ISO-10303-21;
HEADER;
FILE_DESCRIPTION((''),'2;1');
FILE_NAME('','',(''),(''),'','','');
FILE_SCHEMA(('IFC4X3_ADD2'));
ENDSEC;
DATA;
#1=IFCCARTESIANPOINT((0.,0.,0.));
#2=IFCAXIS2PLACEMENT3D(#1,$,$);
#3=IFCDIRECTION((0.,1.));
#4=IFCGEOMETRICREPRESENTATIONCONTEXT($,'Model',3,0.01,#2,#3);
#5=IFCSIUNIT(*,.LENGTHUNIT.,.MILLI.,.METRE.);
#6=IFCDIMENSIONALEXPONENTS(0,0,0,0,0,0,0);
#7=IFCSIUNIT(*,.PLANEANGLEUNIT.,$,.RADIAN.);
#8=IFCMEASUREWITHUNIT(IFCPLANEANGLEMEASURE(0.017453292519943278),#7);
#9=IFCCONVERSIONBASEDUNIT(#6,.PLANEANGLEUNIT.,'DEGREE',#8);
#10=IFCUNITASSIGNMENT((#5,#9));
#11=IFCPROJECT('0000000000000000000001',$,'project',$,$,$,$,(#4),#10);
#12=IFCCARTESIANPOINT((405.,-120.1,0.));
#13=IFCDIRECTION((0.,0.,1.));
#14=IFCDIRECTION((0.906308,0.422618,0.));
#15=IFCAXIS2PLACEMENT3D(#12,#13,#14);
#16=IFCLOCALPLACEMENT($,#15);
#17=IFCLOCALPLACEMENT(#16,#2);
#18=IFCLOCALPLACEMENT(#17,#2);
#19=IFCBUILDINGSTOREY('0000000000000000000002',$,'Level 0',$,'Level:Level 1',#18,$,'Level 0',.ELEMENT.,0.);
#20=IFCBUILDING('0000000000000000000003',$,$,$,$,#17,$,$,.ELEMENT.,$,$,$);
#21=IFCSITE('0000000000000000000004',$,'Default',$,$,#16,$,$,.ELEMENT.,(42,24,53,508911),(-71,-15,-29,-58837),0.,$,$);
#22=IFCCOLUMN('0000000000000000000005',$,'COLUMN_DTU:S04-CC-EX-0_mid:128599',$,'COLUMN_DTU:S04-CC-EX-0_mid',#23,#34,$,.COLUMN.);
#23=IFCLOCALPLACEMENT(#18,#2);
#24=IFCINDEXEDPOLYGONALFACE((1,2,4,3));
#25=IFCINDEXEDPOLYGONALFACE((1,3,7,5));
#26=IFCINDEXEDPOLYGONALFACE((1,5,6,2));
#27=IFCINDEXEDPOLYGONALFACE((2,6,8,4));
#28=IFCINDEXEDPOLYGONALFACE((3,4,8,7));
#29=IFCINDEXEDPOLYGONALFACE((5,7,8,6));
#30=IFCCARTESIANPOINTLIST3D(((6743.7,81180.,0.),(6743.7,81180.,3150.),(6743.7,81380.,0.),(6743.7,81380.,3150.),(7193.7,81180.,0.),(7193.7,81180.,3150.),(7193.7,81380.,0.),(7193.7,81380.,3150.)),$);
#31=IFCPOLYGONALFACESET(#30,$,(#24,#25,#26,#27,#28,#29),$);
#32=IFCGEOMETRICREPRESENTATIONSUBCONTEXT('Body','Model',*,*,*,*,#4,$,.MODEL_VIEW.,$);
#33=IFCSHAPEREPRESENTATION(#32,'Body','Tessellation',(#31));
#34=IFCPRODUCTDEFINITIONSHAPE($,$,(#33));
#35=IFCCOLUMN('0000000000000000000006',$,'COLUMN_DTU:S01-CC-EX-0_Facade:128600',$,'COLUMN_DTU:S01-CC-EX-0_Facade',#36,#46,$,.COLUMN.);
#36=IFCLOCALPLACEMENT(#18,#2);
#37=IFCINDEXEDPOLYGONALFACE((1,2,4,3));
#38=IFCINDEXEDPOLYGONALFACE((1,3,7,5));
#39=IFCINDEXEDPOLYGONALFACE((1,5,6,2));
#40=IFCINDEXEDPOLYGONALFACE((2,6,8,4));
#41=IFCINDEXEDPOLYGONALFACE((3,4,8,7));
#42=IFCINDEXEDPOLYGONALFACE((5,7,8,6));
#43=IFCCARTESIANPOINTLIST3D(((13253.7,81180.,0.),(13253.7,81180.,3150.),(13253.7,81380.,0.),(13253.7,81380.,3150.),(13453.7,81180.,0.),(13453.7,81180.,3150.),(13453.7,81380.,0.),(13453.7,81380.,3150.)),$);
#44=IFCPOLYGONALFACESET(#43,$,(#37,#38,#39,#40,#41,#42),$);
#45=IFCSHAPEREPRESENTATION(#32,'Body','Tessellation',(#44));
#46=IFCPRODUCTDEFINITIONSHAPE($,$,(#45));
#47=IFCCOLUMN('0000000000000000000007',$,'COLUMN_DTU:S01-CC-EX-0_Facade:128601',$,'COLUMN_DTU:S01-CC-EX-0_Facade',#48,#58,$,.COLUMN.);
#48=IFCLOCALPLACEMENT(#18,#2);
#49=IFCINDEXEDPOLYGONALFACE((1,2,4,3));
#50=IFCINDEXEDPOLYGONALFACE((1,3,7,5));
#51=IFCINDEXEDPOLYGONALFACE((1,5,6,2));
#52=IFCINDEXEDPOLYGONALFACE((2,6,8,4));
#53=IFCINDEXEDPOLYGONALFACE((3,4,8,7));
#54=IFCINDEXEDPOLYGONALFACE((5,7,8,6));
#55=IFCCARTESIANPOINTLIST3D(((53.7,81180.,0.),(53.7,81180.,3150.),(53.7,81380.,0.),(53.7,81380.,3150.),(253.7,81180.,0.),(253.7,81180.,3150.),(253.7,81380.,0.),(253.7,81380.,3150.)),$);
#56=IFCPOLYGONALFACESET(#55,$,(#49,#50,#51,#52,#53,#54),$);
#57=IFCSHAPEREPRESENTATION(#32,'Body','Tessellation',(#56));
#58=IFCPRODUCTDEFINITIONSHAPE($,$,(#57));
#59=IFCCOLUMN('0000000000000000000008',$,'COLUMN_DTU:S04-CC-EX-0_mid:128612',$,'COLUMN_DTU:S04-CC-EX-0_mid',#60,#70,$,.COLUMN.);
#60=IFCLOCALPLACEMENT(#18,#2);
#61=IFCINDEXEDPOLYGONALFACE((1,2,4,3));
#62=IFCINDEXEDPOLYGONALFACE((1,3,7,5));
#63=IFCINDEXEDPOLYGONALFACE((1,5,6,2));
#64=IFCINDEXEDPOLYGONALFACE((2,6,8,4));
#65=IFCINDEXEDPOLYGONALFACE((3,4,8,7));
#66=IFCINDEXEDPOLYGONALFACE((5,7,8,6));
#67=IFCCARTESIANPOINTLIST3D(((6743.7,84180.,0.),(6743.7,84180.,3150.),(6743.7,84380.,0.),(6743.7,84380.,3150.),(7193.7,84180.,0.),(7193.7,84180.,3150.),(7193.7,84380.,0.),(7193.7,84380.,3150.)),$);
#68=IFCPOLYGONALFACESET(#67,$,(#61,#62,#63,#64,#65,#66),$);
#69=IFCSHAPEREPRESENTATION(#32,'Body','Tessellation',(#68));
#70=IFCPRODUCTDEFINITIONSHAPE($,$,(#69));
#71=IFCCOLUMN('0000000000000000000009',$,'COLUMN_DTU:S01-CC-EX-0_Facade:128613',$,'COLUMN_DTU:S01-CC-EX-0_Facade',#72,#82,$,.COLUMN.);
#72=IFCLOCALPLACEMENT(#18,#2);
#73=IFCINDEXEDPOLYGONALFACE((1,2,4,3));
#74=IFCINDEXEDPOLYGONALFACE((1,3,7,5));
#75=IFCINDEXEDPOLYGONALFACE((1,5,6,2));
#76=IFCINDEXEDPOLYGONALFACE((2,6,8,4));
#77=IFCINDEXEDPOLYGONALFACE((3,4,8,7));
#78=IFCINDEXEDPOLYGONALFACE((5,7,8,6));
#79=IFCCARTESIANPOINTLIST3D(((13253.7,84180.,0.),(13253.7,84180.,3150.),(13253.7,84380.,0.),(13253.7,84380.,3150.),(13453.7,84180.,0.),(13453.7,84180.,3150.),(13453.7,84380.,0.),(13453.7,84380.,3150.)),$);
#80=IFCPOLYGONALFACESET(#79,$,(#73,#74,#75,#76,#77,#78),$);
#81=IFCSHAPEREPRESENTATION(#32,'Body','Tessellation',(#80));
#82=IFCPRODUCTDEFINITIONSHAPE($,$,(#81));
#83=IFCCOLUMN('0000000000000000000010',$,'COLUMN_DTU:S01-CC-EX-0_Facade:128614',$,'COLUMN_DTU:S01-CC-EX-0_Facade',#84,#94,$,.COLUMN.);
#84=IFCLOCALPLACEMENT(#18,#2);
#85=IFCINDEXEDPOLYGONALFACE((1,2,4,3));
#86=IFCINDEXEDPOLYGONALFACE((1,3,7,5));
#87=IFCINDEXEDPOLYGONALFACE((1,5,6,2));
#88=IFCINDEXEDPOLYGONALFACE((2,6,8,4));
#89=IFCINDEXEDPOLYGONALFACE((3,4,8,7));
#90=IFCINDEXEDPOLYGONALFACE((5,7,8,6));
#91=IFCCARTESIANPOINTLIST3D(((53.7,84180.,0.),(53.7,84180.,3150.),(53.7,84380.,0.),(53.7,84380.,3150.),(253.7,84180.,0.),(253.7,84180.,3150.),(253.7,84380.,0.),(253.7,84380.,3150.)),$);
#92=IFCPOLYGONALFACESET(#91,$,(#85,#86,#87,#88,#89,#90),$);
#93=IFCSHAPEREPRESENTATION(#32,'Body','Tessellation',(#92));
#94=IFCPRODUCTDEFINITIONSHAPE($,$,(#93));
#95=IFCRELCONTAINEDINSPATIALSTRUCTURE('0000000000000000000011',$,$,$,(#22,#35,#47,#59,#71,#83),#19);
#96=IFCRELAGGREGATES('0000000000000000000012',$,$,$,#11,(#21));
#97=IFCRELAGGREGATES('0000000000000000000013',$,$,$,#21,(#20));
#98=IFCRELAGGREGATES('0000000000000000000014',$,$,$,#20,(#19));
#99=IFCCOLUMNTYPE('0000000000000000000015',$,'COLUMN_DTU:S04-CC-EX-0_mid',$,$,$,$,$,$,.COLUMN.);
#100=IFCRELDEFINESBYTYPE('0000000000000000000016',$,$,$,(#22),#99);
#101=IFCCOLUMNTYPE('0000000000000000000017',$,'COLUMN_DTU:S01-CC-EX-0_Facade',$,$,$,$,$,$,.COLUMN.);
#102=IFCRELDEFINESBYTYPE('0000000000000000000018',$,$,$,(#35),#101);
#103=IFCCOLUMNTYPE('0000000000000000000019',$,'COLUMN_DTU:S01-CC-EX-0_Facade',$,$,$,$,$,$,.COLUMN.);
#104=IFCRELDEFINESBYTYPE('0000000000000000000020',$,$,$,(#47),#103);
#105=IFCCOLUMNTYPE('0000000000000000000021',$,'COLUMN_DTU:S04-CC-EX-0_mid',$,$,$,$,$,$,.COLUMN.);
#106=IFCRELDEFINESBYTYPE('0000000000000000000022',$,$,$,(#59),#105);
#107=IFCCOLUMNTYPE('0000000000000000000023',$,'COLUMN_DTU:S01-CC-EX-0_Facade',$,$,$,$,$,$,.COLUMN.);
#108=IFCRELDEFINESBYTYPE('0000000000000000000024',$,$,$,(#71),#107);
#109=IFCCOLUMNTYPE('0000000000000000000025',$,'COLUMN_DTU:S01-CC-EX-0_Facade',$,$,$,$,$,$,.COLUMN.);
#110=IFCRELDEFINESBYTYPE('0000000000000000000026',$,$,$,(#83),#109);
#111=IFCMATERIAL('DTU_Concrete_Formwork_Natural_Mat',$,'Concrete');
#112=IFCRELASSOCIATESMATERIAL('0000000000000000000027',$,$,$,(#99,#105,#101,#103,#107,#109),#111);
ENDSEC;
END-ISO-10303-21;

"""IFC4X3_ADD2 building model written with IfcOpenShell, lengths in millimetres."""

from ifc_helpers import new_model, entity, si_unit, converted_unit, direction, frame, frame_2d, origin, place, context, subcontext, project, spatial, rectangle, extrude, source, transform, mapped, material, material_profile, profile_set, type_object, type_shapes, element, save


model = new_model("IFC4X3_ADD2")

# Units and contexts
model_context = context("Model", 3, precision=0.01, world=origin(), true_north=direction((0.0, 1.0)))
body_context = subcontext(model_context, "Body", "Model", "MODEL_VIEW")
ifc_project = project(units=[si_unit("LENGTHUNIT", "METRE", prefix="MILLI"), converted_unit("PLANEANGLEUNIT", "DEGREE", entity("IfcPlaneAngleMeasure", 0.017453292519943278), si_unit("PLANEANGLEUNIT", "RADIAN"), dimensions=[0, 0, 0, 0, 0, 0, 0])], contexts=[model_context])

# Site, building, storey
site_placement = place(None, frame((405.0, -120.1, 0.0), z_axis=(0.0, 0.0, 1.0), x_axis=(0.906308, 0.422618, 0.0)))
site = spatial("IfcSite", under=ifc_project, at=site_placement, Name="Default", CompositionType="ELEMENT", RefLatitude=(42, 24, 53, 508911), RefLongitude=(-71, -15, -29, -58837), RefElevation=0.0)
building_placement = place(site_placement, origin())
building = spatial("IfcBuilding", under=site, at=building_placement, CompositionType="ELEMENT")
storey_placement = place(building_placement, origin())
storey = spatial("IfcBuildingStorey", under=building, at=storey_placement, Name="Level 0", ObjectType="Level:Level 1", LongName="Level 0", CompositionType="ELEMENT", Elevation=0.0)

# Columns
ifc_material = material(Name="DTU_Concrete_Formwork_Natural_Mat", Category="Concrete")
ifc_material_profile_1 = material_profile(ifc_material, rectangle(XDim=200.0, YDim=200.0, at=frame_2d((0.0, 0.0), x_axis=(1.0, 0.0))), Name="S01-CC-EX-0_Facade")
ifc_profile_set_1 = profile_set([ifc_material_profile_1], Name="S01-CC-EX-0_Facade")
ifc_material_profile_2 = material_profile(ifc_material, rectangle(XDim=200.0, YDim=450.0, at=frame_2d((0.0, 0.0), x_axis=(1.0, 0.0))), Name="S04-CC-EX-0_mid")
ifc_profile_set_2 = profile_set([ifc_material_profile_2], Name="S04-CC-EX-0_mid")
column_type_1 = type_object("IfcColumnType", Name="COLUMN_DTU:S04-CC-EX-0_mid", PredefinedType="COLUMN", material=ifc_profile_set_2)
shared_shape_1 = source(origin(), body_context, "Body", "SweptSolid", [
    extrude(rectangle(XDim=200.0, YDim=450.0, at=frame_2d((0.0, 0.0), x_axis=(1.0, 0.0))), frame((6968.7, 81280.0, 0.0), z_axis=(0.0, 0.0, 1.0), x_axis=(0.0, 1.0, 0.0)), (0.0, 0.0, 1.0), 3150.0),
])
type_shapes(column_type_1, [shared_shape_1])
column_1_placement = place(storey_placement, origin())
element("IfcColumn", 1, at=column_1_placement, inside=storey, type_object=column_type_1, Name="COLUMN_DTU:S04-CC-EX-0_mid:128599", ObjectType="COLUMN_DTU:S04-CC-EX-0_mid", PredefinedType="COLUMN", context=body_context, shape_type="MappedRepresentation", body=[
    mapped(shared_shape_1, transform((0.0, 0.0, 0.0), scale=1.0)),
])
column_type_2 = type_object("IfcColumnType", Name="COLUMN_DTU:S01-CC-EX-0_Facade", PredefinedType="COLUMN", material=ifc_profile_set_1)
shared_shape_2 = source(origin(), body_context, "Body", "SweptSolid", [
    extrude(rectangle(XDim=200.0, YDim=200.0, at=frame_2d((0.0, 0.0), x_axis=(1.0, 0.0))), frame((13353.7, 81280.0, 0.0), z_axis=(0.0, 0.0, 1.0), x_axis=(0.0, 1.0, 0.0)), (0.0, 0.0, 1.0), 3150.0),
])
type_shapes(column_type_2, [shared_shape_2])
column_2_placement = place(storey_placement, origin())
element("IfcColumn", 2, at=column_2_placement, inside=storey, type_object=column_type_2, Name="COLUMN_DTU:S01-CC-EX-0_Facade:128600", ObjectType="COLUMN_DTU:S01-CC-EX-0_Facade", PredefinedType="COLUMN", context=body_context, shape_type="MappedRepresentation", body=[
    mapped(shared_shape_2, transform((0.0, 0.0, 0.0), scale=1.0)),
])
column_type_3 = type_object("IfcColumnType", Name="COLUMN_DTU:S01-CC-EX-0_Facade", PredefinedType="COLUMN", material=ifc_profile_set_1)
shared_shape_3 = source(origin(), body_context, "Body", "SweptSolid", [
    extrude(rectangle(XDim=200.0, YDim=200.0, at=frame_2d((0.0, 0.0), x_axis=(1.0, 0.0))), frame((153.7, 81280.0, 0.0), z_axis=(0.0, 0.0, 1.0), x_axis=(0.0, 1.0, 0.0)), (0.0, 0.0, 1.0), 3150.0),
])
type_shapes(column_type_3, [shared_shape_3])
column_3_placement = place(storey_placement, origin())
element("IfcColumn", 3, at=column_3_placement, inside=storey, type_object=column_type_3, Name="COLUMN_DTU:S01-CC-EX-0_Facade:128601", ObjectType="COLUMN_DTU:S01-CC-EX-0_Facade", PredefinedType="COLUMN", context=body_context, shape_type="MappedRepresentation", body=[
    mapped(shared_shape_3, transform((0.0, 0.0, 0.0), scale=1.0)),
])
column_type_4 = type_object("IfcColumnType", Name="COLUMN_DTU:S04-CC-EX-0_mid", PredefinedType="COLUMN", material=ifc_profile_set_2)
shared_shape_4 = source(origin(), body_context, "Body", "SweptSolid", [
    extrude(rectangle(XDim=200.0, YDim=450.0, at=frame_2d((0.0, 0.0), x_axis=(1.0, 0.0))), frame((6968.7, 84280.0, 0.0), z_axis=(0.0, 0.0, 1.0), x_axis=(0.0, 1.0, 0.0)), (0.0, 0.0, 1.0), 3150.0),
])
type_shapes(column_type_4, [shared_shape_4])
column_4_placement = place(storey_placement, origin())
element("IfcColumn", 4, at=column_4_placement, inside=storey, type_object=column_type_4, Name="COLUMN_DTU:S04-CC-EX-0_mid:128612", ObjectType="COLUMN_DTU:S04-CC-EX-0_mid", PredefinedType="COLUMN", context=body_context, shape_type="MappedRepresentation", body=[
    mapped(shared_shape_4, transform((0.0, 0.0, 0.0), scale=1.0)),
])
column_type_5 = type_object("IfcColumnType", Name="COLUMN_DTU:S01-CC-EX-0_Facade", PredefinedType="COLUMN", material=ifc_profile_set_1)
shared_shape_5 = source(origin(), body_context, "Body", "SweptSolid", [
    extrude(rectangle(XDim=200.0, YDim=200.0, at=frame_2d((0.0, 0.0), x_axis=(1.0, 0.0))), frame((13353.7, 84280.0, 0.0), z_axis=(0.0, 0.0, 1.0), x_axis=(0.0, 1.0, 0.0)), (0.0, 0.0, 1.0), 3150.0),
])
type_shapes(column_type_5, [shared_shape_5])
column_5_placement = place(storey_placement, origin())
element("IfcColumn", 5, at=column_5_placement, inside=storey, type_object=column_type_5, Name="COLUMN_DTU:S01-CC-EX-0_Facade:128613", ObjectType="COLUMN_DTU:S01-CC-EX-0_Facade", PredefinedType="COLUMN", context=body_context, shape_type="MappedRepresentation", body=[
    mapped(shared_shape_5, transform((0.0, 0.0, 0.0), scale=1.0)),
])
column_type_6 = type_object("IfcColumnType", Name="COLUMN_DTU:S01-CC-EX-0_Facade", PredefinedType="COLUMN", material=ifc_profile_set_1)
shared_shape_6 = source(origin(), body_context, "Body", "SweptSolid", [
    extrude(rectangle(XDim=200.0, YDim=200.0, at=frame_2d((0.0, 0.0), x_axis=(1.0, 0.0))), frame((153.7, 84280.0, 0.0), z_axis=(0.0, 0.0, 1.0), x_axis=(0.0, 1.0, 0.0)), (0.0, 0.0, 1.0), 3150.0),
])
type_shapes(column_type_6, [shared_shape_6])
column_6_placement = place(storey_placement, origin())
element("IfcColumn", 6, at=column_6_placement, inside=storey, type_object=column_type_6, Name="COLUMN_DTU:S01-CC-EX-0_Facade:128614", ObjectType="COLUMN_DTU:S01-CC-EX-0_Facade", PredefinedType="COLUMN", context=body_context, shape_type="MappedRepresentation", body=[
    mapped(shared_shape_6, transform((0.0, 0.0, 0.0), scale=1.0)),
])

save(model, "model.ifc")
